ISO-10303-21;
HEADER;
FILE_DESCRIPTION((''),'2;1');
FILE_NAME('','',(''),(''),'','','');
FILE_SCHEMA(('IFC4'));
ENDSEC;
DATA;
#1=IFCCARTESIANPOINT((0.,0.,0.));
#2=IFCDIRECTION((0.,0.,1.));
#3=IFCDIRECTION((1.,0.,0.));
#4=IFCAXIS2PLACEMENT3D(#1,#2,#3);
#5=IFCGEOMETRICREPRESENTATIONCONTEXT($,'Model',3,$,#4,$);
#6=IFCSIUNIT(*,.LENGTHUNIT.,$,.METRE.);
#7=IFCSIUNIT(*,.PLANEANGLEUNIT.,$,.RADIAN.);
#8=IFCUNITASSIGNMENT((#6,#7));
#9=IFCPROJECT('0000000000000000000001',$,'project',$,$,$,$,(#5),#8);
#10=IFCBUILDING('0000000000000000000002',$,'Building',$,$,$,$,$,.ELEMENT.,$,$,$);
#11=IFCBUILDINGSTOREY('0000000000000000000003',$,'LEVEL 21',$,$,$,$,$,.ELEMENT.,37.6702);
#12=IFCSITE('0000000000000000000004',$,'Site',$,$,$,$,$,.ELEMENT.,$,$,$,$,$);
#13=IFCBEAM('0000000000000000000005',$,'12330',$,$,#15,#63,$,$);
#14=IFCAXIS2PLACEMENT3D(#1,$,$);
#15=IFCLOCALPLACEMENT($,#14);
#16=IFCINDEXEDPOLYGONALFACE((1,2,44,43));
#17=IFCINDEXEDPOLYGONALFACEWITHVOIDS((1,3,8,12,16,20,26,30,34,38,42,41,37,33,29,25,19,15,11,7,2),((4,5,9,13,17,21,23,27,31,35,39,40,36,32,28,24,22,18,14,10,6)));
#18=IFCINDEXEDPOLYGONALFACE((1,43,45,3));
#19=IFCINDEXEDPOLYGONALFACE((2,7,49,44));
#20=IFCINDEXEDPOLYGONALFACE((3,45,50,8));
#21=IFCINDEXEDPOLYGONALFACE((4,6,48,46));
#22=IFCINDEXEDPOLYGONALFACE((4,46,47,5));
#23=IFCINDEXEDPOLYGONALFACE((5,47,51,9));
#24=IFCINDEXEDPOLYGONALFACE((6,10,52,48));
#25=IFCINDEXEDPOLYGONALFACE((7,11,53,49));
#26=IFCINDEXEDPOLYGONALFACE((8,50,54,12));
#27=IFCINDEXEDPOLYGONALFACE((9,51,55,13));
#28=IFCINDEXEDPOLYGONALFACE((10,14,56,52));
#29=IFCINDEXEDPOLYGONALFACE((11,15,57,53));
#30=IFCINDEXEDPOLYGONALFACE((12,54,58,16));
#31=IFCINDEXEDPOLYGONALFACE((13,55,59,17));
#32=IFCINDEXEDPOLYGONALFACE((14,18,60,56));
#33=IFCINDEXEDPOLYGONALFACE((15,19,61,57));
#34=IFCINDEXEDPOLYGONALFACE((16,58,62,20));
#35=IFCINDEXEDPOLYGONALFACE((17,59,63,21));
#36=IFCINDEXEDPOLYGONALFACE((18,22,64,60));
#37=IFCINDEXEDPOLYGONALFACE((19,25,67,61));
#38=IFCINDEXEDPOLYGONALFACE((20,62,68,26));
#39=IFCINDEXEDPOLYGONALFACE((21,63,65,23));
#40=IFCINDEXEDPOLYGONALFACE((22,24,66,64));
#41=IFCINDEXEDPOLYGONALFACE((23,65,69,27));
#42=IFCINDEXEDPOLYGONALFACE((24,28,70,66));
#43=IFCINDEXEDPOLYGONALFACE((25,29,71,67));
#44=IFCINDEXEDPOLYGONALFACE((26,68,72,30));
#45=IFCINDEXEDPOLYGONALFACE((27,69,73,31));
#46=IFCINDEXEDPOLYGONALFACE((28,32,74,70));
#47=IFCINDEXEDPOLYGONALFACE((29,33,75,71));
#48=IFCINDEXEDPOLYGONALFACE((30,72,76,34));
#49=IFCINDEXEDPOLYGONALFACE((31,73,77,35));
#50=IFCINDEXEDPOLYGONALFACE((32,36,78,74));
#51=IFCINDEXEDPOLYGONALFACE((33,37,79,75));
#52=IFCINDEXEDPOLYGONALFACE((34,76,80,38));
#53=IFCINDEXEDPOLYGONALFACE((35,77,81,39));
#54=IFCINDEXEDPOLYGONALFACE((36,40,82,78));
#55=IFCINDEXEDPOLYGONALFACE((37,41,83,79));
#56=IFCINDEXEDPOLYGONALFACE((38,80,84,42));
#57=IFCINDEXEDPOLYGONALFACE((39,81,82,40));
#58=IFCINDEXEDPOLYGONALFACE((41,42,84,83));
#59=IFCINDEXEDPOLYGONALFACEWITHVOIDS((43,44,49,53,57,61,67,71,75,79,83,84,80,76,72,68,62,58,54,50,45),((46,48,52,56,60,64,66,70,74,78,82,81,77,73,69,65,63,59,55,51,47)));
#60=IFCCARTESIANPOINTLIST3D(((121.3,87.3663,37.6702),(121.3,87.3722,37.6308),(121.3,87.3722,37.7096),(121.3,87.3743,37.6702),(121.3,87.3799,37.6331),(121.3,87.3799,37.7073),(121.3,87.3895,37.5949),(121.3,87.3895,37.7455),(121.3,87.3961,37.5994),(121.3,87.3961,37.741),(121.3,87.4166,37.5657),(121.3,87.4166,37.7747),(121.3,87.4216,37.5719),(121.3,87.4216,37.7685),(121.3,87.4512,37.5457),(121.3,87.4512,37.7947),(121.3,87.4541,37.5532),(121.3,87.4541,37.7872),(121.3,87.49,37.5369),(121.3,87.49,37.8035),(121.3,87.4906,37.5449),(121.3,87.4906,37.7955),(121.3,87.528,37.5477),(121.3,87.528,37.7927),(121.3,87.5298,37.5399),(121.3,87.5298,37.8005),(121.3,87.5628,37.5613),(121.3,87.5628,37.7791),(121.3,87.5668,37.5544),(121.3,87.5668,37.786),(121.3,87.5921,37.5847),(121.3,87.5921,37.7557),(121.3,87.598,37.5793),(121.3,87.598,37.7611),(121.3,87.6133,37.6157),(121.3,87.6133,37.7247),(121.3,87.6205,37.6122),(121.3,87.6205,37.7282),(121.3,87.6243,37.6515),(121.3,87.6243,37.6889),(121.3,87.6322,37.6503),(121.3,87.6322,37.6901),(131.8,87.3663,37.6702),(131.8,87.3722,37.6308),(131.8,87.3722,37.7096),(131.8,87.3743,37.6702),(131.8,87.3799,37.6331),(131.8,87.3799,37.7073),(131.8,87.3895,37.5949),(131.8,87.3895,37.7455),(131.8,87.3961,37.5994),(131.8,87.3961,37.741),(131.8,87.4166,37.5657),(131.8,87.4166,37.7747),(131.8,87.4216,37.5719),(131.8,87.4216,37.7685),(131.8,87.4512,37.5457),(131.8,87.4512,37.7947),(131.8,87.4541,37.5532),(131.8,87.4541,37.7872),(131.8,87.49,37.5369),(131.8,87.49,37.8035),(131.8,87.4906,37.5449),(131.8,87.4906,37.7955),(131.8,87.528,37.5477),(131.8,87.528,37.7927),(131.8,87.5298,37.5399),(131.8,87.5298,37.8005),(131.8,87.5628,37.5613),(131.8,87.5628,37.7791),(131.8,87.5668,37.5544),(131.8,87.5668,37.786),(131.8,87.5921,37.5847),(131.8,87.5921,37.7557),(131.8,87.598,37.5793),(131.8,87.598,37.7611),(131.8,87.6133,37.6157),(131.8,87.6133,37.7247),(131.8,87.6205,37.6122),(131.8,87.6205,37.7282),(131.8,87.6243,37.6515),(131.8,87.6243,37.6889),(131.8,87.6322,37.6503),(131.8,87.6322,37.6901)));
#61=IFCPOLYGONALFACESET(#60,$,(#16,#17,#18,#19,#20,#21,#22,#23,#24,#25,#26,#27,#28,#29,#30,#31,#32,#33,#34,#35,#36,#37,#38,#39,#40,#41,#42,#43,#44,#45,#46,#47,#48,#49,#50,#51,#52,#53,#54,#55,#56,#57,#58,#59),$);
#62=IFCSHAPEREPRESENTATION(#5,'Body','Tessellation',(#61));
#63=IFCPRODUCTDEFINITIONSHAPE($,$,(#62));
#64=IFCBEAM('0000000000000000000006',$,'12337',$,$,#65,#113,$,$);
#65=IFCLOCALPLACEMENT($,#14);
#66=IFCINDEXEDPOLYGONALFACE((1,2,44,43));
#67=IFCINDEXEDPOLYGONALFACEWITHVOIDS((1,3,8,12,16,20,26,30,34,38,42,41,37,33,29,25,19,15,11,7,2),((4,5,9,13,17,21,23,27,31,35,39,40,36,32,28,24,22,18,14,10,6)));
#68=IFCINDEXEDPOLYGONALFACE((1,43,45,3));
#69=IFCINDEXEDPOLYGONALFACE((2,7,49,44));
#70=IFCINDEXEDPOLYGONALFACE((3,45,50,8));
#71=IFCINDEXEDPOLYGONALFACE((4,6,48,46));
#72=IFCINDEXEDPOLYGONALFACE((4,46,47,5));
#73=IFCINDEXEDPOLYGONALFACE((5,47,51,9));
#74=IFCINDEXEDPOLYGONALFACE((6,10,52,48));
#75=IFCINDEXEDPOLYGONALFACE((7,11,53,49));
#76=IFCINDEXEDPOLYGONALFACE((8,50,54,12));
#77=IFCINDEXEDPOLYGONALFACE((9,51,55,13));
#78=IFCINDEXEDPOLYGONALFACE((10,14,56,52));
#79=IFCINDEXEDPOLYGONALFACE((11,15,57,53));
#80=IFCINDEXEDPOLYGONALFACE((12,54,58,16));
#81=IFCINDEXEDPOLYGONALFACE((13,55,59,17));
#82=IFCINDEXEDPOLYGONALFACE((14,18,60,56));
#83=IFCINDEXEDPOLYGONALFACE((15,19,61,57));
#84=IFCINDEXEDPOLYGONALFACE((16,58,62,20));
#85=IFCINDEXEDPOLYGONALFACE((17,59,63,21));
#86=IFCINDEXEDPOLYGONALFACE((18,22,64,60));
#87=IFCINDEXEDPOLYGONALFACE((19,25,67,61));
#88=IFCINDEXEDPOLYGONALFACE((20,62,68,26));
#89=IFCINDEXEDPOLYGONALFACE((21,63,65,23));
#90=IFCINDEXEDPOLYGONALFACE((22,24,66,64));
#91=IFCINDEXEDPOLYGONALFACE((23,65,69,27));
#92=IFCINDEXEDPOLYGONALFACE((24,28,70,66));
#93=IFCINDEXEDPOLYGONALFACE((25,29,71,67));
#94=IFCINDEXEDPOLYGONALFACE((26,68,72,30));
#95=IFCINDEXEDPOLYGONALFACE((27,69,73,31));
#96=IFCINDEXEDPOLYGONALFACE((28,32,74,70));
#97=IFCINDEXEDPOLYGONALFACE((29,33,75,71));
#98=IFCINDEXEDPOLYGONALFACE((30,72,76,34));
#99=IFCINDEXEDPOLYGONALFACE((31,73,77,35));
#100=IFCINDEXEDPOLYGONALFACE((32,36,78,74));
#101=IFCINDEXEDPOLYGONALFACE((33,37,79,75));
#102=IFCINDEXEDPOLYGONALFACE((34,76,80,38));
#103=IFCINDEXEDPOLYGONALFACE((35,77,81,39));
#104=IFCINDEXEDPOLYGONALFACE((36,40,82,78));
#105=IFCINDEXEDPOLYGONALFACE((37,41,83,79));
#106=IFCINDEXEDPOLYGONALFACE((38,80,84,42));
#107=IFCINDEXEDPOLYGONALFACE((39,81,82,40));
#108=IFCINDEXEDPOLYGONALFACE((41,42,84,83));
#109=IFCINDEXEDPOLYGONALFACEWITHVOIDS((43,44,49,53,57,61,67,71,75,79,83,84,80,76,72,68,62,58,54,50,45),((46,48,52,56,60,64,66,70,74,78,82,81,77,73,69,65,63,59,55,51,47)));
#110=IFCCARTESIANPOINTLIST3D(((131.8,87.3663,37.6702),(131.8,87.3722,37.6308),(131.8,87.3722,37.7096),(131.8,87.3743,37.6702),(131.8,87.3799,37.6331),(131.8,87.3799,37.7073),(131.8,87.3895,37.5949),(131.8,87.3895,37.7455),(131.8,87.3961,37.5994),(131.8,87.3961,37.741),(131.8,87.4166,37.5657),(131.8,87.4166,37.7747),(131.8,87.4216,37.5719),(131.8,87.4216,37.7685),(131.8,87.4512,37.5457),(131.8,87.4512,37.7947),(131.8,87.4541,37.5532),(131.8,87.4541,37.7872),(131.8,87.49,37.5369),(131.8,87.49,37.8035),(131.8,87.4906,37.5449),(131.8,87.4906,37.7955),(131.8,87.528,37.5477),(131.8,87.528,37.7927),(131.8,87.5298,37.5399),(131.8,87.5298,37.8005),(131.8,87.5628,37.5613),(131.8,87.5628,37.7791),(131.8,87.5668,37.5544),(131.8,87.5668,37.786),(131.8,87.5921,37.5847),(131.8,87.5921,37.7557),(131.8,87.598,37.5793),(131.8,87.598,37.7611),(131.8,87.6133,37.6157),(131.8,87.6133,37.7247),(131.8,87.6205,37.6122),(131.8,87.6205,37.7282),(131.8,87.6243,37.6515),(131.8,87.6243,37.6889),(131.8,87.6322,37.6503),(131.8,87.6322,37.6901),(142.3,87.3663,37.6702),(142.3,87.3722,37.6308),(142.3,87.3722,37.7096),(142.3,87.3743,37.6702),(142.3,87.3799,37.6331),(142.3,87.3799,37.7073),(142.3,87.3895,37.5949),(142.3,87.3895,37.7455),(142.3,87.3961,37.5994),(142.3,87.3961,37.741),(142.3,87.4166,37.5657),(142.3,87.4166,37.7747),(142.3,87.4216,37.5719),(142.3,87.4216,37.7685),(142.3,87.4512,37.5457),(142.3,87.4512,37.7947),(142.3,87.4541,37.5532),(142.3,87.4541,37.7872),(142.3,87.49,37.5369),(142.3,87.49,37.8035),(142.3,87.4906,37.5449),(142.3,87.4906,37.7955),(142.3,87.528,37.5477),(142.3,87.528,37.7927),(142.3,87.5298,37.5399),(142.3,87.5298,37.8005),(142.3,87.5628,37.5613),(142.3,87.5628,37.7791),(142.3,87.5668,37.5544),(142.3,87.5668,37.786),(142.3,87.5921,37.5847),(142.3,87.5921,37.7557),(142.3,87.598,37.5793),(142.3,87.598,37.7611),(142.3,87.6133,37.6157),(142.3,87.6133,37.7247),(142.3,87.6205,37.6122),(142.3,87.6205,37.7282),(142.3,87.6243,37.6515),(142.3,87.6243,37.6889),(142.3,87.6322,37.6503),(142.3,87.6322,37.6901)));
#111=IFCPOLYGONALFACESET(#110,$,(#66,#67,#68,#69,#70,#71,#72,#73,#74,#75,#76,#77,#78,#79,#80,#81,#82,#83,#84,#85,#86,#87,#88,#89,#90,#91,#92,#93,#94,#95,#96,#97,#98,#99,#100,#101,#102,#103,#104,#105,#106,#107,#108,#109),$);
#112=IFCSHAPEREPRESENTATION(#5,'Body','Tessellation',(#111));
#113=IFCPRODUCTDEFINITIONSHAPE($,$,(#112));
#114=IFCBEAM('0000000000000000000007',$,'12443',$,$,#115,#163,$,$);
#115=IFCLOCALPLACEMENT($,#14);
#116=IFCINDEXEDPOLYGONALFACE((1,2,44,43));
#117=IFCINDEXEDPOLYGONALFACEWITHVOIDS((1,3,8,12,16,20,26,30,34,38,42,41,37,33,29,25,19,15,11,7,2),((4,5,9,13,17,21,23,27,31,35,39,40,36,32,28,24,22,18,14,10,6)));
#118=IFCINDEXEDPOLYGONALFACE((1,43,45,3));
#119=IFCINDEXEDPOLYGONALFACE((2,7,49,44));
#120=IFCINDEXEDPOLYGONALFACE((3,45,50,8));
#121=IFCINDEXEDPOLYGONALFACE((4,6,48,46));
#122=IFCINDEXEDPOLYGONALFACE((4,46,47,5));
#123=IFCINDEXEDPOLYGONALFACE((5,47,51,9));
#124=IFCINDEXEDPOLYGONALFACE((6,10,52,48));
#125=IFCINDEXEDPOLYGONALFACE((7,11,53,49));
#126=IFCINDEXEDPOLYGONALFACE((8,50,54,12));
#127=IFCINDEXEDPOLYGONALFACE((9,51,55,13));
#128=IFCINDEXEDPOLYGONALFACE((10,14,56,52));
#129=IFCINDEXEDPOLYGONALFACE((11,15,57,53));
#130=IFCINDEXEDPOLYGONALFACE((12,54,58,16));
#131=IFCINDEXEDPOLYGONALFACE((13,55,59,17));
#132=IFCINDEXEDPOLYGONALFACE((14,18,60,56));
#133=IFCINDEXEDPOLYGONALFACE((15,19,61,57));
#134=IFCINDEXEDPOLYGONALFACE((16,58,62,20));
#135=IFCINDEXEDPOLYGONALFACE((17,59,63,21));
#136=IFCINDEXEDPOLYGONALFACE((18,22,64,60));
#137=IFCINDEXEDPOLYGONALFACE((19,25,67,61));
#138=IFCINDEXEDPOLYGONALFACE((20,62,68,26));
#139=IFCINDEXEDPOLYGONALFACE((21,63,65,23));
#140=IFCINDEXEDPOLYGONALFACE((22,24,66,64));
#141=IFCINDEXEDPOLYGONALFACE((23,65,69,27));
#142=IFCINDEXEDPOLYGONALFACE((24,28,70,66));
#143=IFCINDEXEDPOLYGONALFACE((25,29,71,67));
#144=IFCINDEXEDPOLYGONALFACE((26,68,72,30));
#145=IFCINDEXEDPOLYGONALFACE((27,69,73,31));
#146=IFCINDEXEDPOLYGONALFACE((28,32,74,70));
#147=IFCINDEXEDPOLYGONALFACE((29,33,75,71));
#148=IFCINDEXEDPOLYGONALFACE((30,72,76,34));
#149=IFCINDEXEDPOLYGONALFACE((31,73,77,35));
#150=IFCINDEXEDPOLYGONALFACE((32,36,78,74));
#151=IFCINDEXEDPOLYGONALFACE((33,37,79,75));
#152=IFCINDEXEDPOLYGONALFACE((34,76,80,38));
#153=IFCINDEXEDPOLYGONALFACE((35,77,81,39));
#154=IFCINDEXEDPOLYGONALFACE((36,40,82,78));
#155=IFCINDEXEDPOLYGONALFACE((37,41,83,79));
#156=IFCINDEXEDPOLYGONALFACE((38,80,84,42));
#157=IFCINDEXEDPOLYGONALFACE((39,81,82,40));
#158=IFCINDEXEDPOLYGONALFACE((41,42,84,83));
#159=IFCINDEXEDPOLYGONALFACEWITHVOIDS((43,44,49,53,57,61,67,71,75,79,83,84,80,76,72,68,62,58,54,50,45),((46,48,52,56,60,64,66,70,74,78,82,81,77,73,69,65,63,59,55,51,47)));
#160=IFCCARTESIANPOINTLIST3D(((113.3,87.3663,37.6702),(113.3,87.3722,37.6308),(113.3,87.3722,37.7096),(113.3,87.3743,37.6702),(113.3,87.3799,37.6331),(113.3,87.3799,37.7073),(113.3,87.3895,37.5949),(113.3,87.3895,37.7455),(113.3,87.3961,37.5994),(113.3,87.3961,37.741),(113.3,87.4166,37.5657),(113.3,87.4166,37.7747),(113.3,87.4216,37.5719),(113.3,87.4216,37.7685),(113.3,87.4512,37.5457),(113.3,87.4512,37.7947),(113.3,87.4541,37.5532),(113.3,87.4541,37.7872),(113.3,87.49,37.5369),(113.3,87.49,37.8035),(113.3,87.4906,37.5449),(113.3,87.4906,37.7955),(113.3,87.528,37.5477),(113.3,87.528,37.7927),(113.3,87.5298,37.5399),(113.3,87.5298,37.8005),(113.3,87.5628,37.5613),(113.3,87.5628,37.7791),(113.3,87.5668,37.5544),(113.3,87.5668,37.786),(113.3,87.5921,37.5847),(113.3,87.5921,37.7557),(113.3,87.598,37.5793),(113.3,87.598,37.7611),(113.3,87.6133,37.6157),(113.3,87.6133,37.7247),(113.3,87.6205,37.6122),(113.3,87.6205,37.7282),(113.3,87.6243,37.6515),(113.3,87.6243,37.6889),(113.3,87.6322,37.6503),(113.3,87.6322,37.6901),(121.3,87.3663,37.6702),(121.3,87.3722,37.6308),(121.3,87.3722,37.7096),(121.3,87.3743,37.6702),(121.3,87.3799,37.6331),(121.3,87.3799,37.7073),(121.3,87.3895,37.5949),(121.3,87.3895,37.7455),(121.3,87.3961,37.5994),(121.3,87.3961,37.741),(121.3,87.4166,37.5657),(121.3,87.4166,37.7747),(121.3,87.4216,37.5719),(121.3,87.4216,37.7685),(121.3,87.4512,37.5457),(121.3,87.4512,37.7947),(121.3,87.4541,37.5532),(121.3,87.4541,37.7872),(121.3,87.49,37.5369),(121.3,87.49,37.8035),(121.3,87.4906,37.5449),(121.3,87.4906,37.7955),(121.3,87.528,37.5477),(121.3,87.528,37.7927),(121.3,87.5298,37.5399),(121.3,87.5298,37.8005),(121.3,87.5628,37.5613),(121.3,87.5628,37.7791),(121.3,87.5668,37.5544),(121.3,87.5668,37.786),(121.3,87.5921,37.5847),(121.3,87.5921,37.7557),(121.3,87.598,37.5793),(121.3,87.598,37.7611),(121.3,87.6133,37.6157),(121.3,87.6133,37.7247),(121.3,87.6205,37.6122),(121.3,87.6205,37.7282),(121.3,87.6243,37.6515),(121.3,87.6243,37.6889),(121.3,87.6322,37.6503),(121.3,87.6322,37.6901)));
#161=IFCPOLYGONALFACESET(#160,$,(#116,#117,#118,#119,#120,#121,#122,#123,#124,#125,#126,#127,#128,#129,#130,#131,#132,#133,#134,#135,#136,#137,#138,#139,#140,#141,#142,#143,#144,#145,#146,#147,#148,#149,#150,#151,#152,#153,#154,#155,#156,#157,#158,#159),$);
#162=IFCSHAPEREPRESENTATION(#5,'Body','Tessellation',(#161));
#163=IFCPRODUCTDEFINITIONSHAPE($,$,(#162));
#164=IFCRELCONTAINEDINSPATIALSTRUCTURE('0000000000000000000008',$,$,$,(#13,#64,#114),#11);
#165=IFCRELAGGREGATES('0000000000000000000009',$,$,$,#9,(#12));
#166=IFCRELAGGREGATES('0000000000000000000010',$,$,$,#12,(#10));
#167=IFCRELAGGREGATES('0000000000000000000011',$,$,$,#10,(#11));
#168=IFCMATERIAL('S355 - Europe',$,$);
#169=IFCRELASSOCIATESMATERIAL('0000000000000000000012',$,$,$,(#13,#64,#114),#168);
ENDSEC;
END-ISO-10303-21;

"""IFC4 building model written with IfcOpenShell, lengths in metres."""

from ifc_helpers import new_model, si_unit, frame, origin_with_axes, origin_2d_with_axis, place, context, project, spatial, hollow_circle, extrude, material, material_profile, profile_set, profile_usage, element, save


model = new_model("IFC4")

# Units and contexts
model_context = context("Model", 3, world=origin_with_axes())
ifc_project = project(units=[si_unit("LENGTHUNIT", "METRE"), si_unit("PLANEANGLEUNIT", "RADIAN")], contexts=[model_context])

# Site, building, storey
site = spatial("IfcSite", under=ifc_project, Name="Site", CompositionType="ELEMENT")
building = spatial("IfcBuilding", under=site, Name="Building", CompositionType="ELEMENT")
storey = spatial("IfcBuildingStorey", under=building, Name="LEVEL 21", CompositionType="ELEMENT", Elevation=37.6702)

# Beams
ifc_material = material(Name="S355 - Europe")
ifc_material_profile_1 = material_profile(ifc_material, hollow_circle(Radius=0.1337, WallThickness=0.008, at=origin_2d_with_axis()))
ifc_profile_set_1 = profile_set([ifc_material_profile_1])
ifc_profile_usage_1 = profile_usage(ifc_profile_set_1, cardinal=10)
beam_1_placement = place(None, frame((131.8, 87.5, 37.6702), z_axis=(-1.0, 0.0, 0.0), x_axis=(0.0, -1.0, 0.0)))
element("IfcBeam", 1, at=beam_1_placement, inside=storey, material=ifc_profile_usage_1, Name="12330", context=model_context, shape_type="SweptSolid", body=[
    extrude(hollow_circle(Radius=0.1337, WallThickness=0.008, at=origin_2d_with_axis()), origin_with_axes(), (0.0, 0.0, 1.0), 10.5),
])
ifc_material_profile_2 = material_profile(ifc_material, hollow_circle(Radius=0.1337, WallThickness=0.008, at=origin_2d_with_axis()))
ifc_profile_set_2 = profile_set([ifc_material_profile_2])
ifc_profile_usage_2 = profile_usage(ifc_profile_set_2, cardinal=10)
beam_2_placement = place(None, frame((142.3, 87.5, 37.6702), z_axis=(-1.0, 0.0, 0.0), x_axis=(0.0, -1.0, 0.0)))
element("IfcBeam", 2, at=beam_2_placement, inside=storey, material=ifc_profile_usage_2, Name="12337", context=model_context, shape_type="SweptSolid", body=[
    extrude(hollow_circle(Radius=0.1337, WallThickness=0.008, at=origin_2d_with_axis()), origin_with_axes(), (0.0, 0.0, 1.0), 10.5),
])
ifc_material_profile_3 = material_profile(ifc_material, hollow_circle(Radius=0.1337, WallThickness=0.008, at=origin_2d_with_axis()))
ifc_profile_set_3 = profile_set([ifc_material_profile_3])
ifc_profile_usage_3 = profile_usage(ifc_profile_set_3, cardinal=10)
beam_3_placement = place(None, frame((121.3, 87.5, 37.6702), z_axis=(-1.0, 0.0, 0.0), x_axis=(0.0, -1.0, 0.0)))
element("IfcBeam", 3, at=beam_3_placement, inside=storey, material=ifc_profile_usage_3, Name="12443", context=model_context, shape_type="SweptSolid", body=[
    extrude(hollow_circle(Radius=0.1337, WallThickness=0.008, at=origin_2d_with_axis()), origin_with_axes(), (0.0, 0.0, 1.0), 8.0),
])

save(model, "model.ifc")
